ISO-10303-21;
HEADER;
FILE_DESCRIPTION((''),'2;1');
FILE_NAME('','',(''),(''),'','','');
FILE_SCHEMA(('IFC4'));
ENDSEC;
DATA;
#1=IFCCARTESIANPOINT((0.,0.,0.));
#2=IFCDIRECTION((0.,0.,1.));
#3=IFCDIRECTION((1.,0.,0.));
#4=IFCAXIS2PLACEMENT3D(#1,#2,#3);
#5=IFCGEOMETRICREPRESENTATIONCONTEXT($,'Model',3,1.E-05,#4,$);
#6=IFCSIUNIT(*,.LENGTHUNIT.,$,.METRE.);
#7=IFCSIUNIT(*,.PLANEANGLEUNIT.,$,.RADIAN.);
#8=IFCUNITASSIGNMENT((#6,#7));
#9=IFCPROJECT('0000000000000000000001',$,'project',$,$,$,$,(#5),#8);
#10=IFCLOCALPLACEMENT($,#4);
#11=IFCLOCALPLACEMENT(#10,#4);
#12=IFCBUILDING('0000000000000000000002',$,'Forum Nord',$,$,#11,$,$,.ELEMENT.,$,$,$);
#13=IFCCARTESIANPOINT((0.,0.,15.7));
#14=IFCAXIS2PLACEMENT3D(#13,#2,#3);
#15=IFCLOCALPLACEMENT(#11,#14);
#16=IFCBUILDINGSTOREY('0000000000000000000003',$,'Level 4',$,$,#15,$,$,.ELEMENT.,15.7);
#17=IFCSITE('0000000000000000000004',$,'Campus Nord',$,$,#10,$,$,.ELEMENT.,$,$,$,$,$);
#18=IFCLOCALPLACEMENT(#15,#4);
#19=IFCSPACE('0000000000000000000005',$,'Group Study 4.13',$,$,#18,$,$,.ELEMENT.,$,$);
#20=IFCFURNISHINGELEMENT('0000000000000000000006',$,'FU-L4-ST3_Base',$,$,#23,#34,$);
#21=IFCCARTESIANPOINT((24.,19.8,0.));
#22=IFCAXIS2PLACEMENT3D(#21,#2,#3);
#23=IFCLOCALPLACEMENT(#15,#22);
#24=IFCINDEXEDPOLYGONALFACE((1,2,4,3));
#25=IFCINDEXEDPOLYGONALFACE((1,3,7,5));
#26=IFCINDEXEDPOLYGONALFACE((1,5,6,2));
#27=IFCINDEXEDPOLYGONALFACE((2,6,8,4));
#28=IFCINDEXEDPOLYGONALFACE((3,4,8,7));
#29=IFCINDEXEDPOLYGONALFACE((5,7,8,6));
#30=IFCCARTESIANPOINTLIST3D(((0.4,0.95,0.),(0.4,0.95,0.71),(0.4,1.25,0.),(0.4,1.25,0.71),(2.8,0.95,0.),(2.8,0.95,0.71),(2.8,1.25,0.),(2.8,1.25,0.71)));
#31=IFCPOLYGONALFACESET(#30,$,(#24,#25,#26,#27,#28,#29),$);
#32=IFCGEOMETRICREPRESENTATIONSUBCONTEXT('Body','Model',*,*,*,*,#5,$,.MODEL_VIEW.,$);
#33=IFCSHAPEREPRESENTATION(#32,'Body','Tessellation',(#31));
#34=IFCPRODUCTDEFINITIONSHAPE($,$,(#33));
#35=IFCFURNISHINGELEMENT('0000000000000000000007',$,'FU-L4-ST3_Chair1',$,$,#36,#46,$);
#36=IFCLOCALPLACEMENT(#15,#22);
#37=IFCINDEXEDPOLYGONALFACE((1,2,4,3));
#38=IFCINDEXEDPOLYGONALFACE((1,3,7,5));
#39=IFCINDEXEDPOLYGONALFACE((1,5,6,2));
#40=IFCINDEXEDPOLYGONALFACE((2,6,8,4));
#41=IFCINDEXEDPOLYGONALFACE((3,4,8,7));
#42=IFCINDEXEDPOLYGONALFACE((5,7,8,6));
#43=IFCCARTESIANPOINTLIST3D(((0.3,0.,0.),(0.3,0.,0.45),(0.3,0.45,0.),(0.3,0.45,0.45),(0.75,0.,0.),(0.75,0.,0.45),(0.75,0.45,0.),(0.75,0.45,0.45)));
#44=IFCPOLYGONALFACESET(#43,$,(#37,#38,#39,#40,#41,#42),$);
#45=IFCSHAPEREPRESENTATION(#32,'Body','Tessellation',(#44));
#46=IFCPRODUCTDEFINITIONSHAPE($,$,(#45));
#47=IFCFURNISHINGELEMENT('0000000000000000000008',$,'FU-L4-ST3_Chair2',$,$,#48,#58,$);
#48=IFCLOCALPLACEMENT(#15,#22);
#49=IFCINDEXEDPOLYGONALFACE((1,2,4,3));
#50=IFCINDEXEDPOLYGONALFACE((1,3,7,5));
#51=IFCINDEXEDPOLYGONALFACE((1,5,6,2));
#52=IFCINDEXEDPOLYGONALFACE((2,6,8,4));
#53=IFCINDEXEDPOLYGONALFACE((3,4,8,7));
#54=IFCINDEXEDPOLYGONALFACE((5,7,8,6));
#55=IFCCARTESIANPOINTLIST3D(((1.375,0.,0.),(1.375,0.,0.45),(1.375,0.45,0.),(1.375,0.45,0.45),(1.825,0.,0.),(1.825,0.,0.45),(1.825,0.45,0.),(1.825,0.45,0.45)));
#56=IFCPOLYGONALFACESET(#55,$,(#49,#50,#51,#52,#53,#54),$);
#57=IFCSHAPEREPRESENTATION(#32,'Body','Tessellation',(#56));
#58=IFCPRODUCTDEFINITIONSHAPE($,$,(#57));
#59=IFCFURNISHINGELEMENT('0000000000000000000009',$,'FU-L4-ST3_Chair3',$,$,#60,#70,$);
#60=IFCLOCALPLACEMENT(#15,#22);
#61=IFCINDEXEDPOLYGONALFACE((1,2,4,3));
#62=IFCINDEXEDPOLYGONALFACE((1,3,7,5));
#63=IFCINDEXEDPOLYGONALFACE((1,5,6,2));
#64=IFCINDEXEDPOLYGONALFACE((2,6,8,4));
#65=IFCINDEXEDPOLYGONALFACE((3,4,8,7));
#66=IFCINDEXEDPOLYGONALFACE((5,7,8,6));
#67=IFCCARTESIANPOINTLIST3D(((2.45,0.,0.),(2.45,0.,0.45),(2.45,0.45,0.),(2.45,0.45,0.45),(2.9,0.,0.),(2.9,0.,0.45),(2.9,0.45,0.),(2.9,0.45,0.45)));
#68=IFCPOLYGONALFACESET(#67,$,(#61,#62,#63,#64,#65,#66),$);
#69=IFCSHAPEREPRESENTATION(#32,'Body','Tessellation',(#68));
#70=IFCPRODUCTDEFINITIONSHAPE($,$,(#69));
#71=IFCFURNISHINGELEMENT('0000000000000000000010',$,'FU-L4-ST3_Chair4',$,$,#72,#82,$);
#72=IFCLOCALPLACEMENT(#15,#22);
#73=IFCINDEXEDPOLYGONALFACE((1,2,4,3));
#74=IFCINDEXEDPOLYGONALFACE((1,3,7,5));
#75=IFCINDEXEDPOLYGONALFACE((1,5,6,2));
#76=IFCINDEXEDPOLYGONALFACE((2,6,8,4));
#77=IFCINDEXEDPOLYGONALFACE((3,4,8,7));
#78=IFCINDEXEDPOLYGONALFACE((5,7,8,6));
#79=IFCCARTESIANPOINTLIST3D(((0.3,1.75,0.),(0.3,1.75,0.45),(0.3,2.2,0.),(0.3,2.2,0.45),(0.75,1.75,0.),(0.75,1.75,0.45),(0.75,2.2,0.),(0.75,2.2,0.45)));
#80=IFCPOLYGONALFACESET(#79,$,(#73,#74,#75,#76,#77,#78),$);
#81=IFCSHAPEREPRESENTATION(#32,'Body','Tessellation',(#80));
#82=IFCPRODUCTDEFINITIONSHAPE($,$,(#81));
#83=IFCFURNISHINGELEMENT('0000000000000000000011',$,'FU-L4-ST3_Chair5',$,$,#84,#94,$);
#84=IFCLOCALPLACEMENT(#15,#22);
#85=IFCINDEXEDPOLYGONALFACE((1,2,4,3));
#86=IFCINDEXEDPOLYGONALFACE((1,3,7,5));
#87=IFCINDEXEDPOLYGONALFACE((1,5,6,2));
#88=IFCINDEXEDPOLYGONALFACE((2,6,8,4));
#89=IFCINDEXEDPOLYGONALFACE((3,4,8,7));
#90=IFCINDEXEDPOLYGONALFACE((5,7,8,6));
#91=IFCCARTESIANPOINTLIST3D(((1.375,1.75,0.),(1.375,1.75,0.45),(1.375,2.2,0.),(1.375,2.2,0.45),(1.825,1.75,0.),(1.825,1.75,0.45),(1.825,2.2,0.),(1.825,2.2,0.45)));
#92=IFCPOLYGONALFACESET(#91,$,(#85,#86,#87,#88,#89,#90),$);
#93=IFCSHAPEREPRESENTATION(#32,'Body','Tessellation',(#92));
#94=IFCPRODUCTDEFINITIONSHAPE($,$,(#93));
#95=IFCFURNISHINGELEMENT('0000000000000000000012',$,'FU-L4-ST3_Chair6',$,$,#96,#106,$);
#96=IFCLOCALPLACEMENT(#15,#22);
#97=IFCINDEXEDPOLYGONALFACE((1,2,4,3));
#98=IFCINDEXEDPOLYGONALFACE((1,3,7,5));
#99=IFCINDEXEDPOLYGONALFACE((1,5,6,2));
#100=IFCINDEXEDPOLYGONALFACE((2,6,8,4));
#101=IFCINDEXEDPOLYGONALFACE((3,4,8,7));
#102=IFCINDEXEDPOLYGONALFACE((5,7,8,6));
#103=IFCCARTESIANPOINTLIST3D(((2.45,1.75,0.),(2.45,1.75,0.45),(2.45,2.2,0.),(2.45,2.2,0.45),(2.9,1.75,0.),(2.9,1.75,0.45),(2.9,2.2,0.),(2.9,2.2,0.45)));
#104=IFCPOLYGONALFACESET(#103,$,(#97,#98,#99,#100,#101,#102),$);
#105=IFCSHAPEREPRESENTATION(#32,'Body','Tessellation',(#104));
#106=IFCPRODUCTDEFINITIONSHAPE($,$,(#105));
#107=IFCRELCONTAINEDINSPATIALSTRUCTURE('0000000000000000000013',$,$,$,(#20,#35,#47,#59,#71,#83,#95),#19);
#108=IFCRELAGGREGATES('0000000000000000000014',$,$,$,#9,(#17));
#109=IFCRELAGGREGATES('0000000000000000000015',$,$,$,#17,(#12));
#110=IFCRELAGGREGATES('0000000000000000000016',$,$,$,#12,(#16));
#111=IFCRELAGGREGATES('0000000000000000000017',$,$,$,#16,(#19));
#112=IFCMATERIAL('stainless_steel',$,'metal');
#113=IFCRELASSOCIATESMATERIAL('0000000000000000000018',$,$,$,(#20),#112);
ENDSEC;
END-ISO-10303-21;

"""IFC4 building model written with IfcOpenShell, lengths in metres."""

from ifc_helpers import new_model, si_unit, frame, frame_2d, origin_with_axes, place, context, subcontext, project, spatial, rectangle, extrude, material, element, save


model = new_model("IFC4")

# Units and contexts
model_context = context("Model", 3, precision=1e-05, world=origin_with_axes())
body_context = subcontext(model_context, "Body", "Model", "MODEL_VIEW")
ifc_project = project(units=[si_unit("LENGTHUNIT", "METRE"), si_unit("PLANEANGLEUNIT", "RADIAN")], contexts=[model_context])

# Site, building, storey
site_placement = place(None, origin_with_axes())
site = spatial("IfcSite", under=ifc_project, at=site_placement, Name="Campus Nord", CompositionType="ELEMENT")
building_placement = place(site_placement, origin_with_axes())
building = spatial("IfcBuilding", under=site, at=building_placement, Name="Forum Nord", CompositionType="ELEMENT")
storey_placement = place(building_placement, frame((0.0, 0.0, 15.7), z_axis=(0.0, 0.0, 1.0), x_axis=(1.0, 0.0, 0.0)))
storey = spatial("IfcBuildingStorey", under=building, at=storey_placement, Name="Level 4", CompositionType="ELEMENT", Elevation=15.7)

# Shared definitions
ifc_material_1 = material(Name="stainless_steel", Category="metal")

# Shared definitions
space_1_placement = place(storey_placement, origin_with_axes())
space_1 = spatial("IfcSpace", under=storey, at=space_1_placement, Name="Group Study 4.13", CompositionType="ELEMENT")

# Furnishing elements
furnishing_1_placement = place(storey_placement, frame((24.0, 19.8, 0.0), z_axis=(0.0, 0.0, 1.0), x_axis=(1.0, 0.0, 0.0)))
element("IfcFurnishingElement", 1, at=furnishing_1_placement, inside=space_1, material=ifc_material_1, Name="FU-L4-ST3_Base", context=body_context, shape_type="SweptSolid", body=[
    extrude(rectangle(XDim=2.4, YDim=0.3, at=frame_2d((1.6, 1.1), x_axis=(1.0, 0.0))), origin_with_axes(), (0.0, 0.0, 1.0), 0.71),
])
furnishing_2_placement = place(storey_placement, frame((24.0, 19.8, 0.0), z_axis=(0.0, 0.0, 1.0), x_axis=(1.0, 0.0, 0.0)))
element("IfcFurnishingElement", 2, at=furnishing_2_placement, inside=space_1, Name="FU-L4-ST3_Chair1", context=body_context, shape_type="SweptSolid", body=[
    extrude(rectangle(XDim=0.45, YDim=0.45, at=frame_2d((0.525, 0.225), x_axis=(1.0, 0.0))), origin_with_axes(), (0.0, 0.0, 1.0), 0.45),
])
furnishing_3_placement = place(storey_placement, frame((24.0, 19.8, 0.0), z_axis=(0.0, 0.0, 1.0), x_axis=(1.0, 0.0, 0.0)))
element("IfcFurnishingElement", 3, at=furnishing_3_placement, inside=space_1, Name="FU-L4-ST3_Chair2", context=body_context, shape_type="SweptSolid", body=[
    extrude(rectangle(XDim=0.45, YDim=0.45, at=frame_2d((1.6, 0.225), x_axis=(1.0, 0.0))), origin_with_axes(), (0.0, 0.0, 1.0), 0.45),
])
furnishing_4_placement = place(storey_placement, frame((24.0, 19.8, 0.0), z_axis=(0.0, 0.0, 1.0), x_axis=(1.0, 0.0, 0.0)))
element("IfcFurnishingElement", 4, at=furnishing_4_placement, inside=space_1, Name="FU-L4-ST3_Chair3", context=body_context, shape_type="SweptSolid", body=[
    extrude(rectangle(XDim=0.45, YDim=0.45, at=frame_2d((2.675, 0.225), x_axis=(1.0, 0.0))), origin_with_axes(), (0.0, 0.0, 1.0), 0.45),
])
furnishing_5_placement = place(storey_placement, frame((24.0, 19.8, 0.0), z_axis=(0.0, 0.0, 1.0), x_axis=(1.0, 0.0, 0.0)))
element("IfcFurnishingElement", 5, at=furnishing_5_placement, inside=space_1, Name="FU-L4-ST3_Chair4", context=body_context, shape_type="SweptSolid", body=[
    extrude(rectangle(XDim=0.45, YDim=0.45, at=frame_2d((0.525, 1.975), x_axis=(1.0, 0.0))), origin_with_axes(), (0.0, 0.0, 1.0), 0.45),
])
furnishing_6_placement = place(storey_placement, frame((24.0, 19.8, 0.0), z_axis=(0.0, 0.0, 1.0), x_axis=(1.0, 0.0, 0.0)))
element("IfcFurnishingElement", 6, at=furnishing_6_placement, inside=space_1, Name="FU-L4-ST3_Chair5", context=body_context, shape_type="SweptSolid", body=[
    extrude(rectangle(XDim=0.45, YDim=0.45, at=frame_2d((1.6, 1.975), x_axis=(1.0, 0.0))), origin_with_axes(), (0.0, 0.0, 1.0), 0.45),
])
furnishing_7_placement = place(storey_placement, frame((24.0, 19.8, 0.0), z_axis=(0.0, 0.0, 1.0), x_axis=(1.0, 0.0, 0.0)))
element("IfcFurnishingElement", 7, at=furnishing_7_placement, inside=space_1, Name="FU-L4-ST3_Chair6", context=body_context, shape_type="SweptSolid", body=[
    extrude(rectangle(XDim=0.45, YDim=0.45, at=frame_2d((2.675, 1.975), x_axis=(1.0, 0.0))), origin_with_axes(), (0.0, 0.0, 1.0), 0.45),
])

save(model, "model.ifc")
